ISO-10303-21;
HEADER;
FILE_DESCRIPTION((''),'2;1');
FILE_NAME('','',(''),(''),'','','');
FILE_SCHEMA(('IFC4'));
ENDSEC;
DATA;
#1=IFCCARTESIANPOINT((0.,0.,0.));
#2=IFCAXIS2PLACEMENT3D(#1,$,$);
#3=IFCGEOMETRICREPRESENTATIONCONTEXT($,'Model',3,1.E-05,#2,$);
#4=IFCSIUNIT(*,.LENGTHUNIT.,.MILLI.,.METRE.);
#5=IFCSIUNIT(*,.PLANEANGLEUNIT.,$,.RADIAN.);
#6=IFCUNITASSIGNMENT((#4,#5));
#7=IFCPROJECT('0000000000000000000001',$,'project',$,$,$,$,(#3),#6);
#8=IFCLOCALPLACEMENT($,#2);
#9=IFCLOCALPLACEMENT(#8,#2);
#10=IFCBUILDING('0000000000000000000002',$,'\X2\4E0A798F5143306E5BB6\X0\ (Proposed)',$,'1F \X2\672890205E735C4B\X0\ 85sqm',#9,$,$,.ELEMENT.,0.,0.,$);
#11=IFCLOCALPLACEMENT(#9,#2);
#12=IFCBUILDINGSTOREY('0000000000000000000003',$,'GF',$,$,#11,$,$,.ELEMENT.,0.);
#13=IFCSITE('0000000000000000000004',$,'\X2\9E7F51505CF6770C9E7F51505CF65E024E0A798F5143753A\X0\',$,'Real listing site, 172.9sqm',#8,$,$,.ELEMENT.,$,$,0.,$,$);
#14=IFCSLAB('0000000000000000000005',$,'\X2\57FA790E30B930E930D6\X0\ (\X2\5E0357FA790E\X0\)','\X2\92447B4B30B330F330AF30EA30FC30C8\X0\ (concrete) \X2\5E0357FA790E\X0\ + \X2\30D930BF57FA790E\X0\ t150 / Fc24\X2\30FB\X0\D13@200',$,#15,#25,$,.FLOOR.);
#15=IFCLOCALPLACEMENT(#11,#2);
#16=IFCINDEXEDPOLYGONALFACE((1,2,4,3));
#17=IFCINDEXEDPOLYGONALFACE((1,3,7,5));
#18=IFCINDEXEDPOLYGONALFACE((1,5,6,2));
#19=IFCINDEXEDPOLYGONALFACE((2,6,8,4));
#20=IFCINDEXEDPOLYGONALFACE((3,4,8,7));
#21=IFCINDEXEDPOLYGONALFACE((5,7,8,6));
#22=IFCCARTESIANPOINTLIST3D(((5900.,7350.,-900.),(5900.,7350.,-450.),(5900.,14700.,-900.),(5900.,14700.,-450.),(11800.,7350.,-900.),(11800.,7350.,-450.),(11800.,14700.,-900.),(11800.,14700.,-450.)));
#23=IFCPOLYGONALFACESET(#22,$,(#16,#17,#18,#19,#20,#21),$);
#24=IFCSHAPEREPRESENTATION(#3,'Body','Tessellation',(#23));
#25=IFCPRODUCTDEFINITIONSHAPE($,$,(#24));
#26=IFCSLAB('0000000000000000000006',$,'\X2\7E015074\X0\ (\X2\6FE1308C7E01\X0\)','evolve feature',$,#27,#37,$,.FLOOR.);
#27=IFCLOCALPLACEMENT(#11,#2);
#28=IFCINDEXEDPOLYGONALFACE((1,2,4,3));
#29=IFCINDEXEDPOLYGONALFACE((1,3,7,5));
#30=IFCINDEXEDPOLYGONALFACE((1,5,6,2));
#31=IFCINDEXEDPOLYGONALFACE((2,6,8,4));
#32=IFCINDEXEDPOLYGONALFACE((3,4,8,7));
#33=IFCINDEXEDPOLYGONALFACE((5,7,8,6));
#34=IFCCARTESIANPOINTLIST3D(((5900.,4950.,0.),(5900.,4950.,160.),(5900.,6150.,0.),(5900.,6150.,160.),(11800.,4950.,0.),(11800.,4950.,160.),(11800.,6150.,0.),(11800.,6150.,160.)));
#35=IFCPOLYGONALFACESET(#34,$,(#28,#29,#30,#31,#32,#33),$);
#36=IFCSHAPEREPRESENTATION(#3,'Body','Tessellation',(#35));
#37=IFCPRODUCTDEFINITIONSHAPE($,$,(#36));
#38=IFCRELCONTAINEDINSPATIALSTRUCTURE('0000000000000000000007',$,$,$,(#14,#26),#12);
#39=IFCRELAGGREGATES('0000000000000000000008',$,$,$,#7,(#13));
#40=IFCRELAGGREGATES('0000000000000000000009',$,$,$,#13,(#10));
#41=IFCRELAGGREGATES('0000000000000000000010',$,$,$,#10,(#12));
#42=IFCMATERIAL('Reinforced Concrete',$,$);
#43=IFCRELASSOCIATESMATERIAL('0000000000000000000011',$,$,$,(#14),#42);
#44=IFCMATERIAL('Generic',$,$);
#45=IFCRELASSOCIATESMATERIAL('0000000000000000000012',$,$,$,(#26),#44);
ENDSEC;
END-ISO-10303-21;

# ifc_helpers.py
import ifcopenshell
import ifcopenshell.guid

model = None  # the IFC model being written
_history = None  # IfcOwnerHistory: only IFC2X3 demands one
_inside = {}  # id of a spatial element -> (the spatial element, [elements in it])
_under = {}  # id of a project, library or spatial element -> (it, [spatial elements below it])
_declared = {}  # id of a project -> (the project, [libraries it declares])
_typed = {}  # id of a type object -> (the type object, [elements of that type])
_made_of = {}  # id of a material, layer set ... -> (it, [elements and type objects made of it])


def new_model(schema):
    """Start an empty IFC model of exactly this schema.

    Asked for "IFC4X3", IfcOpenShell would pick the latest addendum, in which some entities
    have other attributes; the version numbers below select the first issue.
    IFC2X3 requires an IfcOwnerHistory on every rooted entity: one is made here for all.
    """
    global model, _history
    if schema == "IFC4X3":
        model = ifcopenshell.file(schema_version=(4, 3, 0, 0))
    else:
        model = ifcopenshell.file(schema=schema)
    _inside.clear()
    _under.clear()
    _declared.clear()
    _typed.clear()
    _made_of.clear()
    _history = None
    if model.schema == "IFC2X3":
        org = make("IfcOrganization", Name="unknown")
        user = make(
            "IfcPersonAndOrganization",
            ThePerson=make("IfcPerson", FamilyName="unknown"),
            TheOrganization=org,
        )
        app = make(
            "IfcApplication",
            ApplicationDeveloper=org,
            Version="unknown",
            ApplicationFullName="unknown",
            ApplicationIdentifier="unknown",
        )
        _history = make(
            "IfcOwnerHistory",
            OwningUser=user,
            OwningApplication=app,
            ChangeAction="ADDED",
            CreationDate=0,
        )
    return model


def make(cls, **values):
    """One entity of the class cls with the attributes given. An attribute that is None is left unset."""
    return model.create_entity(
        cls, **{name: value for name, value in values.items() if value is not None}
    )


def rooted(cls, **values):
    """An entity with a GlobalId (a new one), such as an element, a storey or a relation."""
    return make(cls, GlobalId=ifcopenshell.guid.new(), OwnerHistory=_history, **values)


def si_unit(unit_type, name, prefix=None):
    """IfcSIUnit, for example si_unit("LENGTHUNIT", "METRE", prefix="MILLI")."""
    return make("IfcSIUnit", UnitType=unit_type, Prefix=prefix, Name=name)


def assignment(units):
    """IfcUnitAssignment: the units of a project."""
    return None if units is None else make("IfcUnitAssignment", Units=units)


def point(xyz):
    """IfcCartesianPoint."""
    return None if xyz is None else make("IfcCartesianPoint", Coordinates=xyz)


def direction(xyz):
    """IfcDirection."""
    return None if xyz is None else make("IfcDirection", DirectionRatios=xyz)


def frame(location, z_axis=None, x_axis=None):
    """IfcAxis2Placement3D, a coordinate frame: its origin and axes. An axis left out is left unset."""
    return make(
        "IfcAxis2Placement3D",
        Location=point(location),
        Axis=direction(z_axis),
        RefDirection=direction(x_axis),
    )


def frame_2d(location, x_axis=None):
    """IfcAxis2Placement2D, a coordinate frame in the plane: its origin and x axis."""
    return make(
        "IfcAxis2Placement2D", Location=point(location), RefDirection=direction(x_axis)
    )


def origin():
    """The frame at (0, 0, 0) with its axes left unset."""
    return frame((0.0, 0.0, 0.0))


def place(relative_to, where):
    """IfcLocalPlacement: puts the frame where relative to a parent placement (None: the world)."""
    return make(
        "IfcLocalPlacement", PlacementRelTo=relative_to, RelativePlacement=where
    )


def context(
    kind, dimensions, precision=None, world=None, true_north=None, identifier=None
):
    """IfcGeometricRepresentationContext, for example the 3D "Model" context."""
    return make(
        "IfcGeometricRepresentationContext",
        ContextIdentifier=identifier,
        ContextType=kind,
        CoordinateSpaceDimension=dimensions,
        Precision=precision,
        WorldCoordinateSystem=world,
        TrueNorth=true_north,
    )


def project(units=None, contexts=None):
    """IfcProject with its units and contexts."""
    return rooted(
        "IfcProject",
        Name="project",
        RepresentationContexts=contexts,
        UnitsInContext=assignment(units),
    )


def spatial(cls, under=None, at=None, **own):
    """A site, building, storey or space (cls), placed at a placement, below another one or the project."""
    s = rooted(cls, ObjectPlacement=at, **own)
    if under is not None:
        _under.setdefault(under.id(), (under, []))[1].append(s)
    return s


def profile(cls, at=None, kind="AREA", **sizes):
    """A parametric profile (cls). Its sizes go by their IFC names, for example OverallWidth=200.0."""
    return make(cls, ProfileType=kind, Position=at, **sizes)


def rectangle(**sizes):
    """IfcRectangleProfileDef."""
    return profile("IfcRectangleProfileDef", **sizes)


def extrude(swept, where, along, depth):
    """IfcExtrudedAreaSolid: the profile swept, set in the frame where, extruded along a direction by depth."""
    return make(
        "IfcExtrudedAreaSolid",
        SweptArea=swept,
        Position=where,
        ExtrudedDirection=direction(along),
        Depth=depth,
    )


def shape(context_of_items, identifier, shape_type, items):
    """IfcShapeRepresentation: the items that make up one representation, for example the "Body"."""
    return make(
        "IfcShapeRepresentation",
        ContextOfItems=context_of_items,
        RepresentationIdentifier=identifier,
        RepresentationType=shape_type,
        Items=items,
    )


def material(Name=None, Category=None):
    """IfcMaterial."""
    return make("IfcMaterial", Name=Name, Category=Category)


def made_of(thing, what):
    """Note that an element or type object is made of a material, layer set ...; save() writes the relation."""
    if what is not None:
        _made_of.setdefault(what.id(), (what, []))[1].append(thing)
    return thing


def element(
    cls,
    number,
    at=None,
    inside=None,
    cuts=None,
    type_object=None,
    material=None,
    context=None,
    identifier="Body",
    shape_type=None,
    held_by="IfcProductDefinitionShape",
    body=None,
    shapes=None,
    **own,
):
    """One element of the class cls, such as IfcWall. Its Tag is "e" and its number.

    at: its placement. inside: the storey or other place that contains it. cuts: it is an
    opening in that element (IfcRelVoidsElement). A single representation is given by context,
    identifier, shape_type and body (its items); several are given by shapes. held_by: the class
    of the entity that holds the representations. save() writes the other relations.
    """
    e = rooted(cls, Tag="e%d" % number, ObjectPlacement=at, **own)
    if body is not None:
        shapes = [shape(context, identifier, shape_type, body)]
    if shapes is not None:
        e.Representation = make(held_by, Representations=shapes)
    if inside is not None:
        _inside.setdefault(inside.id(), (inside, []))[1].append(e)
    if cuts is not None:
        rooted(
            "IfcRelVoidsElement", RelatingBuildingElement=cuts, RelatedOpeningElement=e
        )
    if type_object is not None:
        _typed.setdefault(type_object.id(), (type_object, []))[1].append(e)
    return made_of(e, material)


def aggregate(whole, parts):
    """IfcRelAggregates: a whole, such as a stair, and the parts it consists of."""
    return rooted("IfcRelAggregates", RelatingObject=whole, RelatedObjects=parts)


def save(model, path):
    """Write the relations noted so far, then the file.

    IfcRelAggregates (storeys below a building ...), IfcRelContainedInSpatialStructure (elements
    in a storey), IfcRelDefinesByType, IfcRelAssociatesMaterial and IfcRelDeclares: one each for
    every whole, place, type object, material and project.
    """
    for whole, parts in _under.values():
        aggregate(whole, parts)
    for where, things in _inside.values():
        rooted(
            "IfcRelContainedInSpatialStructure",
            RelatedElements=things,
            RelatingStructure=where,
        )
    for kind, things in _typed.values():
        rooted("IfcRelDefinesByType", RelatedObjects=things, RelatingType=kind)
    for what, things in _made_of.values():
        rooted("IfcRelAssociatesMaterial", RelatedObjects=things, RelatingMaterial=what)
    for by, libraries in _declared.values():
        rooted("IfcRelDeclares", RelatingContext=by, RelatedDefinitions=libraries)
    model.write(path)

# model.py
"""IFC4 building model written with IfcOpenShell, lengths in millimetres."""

from ifc_helpers import new_model, si_unit, frame, frame_2d, origin, place, context, project, spatial, rectangle, extrude, material, element, save


model = new_model("IFC4")

# Units and contexts
model_context = context("Model", 3, precision=1e-05, world=origin())
ifc_project = project(units=[si_unit("LENGTHUNIT", "METRE", prefix="MILLI"), si_unit("PLANEANGLEUNIT", "RADIAN")], contexts=[model_context])

# Site, building, storey
site_placement = place(None, origin())
site = spatial("IfcSite", under=ifc_project, at=site_placement, Name="鹿児島県鹿児島市上福元町", ObjectType="Real listing site, 172.9sqm", CompositionType="ELEMENT", RefElevation=0.0)
building_placement = place(site_placement, origin())
building = spatial("IfcBuilding", under=site, at=building_placement, Name="上福元の家 (Proposed)", ObjectType="1F 木造平屋 85sqm", CompositionType="ELEMENT", ElevationOfRefHeight=0.0, ElevationOfTerrain=0.0)
storey_placement = place(building_placement, origin())
storey = spatial("IfcBuildingStorey", under=building, at=storey_placement, Name="GF", CompositionType="ELEMENT", Elevation=0.0)

# Slabs
ifc_material_1 = material(Name="Reinforced Concrete")
slab_1_placement = place(storey_placement, frame((2950.0, 3675.0, -450.0)))
element("IfcSlab", 1, at=slab_1_placement, inside=storey, material=ifc_material_1, Name="基礎スラブ (布基礎)", Description="鉄筋コンクリート (concrete) 布基礎 + ベタ基礎 t150 / Fc24・D13@200", PredefinedType="FLOOR", context=model_context, shape_type="SweptSolid", body=[
    extrude(rectangle(XDim=5900.0, YDim=7350.0, at=frame_2d((2950.0, 3675.0))), frame((2950.0, 3675.0, -450.0)), (0.0, 0.0, 1.0), 450.0),
])
ifc_material_2 = material(Name="Generic")
slab_2_placement = place(storey_placement, frame((2950.0, 2475.0, 0.0)))
element("IfcSlab", 2, at=slab_2_placement, inside=storey, material=ifc_material_2, Name="縁側 (濡れ縁)", Description="evolve feature", PredefinedType="FLOOR", context=model_context, shape_type="SweptSolid", body=[
    extrude(rectangle(XDim=5900.0, YDim=1200.0, at=frame_2d((2950.0, 600.0))), frame((2950.0, 2475.0, 0.0)), (0.0, 0.0, 1.0), 160.0),
])

save(model, "model.ifc")
